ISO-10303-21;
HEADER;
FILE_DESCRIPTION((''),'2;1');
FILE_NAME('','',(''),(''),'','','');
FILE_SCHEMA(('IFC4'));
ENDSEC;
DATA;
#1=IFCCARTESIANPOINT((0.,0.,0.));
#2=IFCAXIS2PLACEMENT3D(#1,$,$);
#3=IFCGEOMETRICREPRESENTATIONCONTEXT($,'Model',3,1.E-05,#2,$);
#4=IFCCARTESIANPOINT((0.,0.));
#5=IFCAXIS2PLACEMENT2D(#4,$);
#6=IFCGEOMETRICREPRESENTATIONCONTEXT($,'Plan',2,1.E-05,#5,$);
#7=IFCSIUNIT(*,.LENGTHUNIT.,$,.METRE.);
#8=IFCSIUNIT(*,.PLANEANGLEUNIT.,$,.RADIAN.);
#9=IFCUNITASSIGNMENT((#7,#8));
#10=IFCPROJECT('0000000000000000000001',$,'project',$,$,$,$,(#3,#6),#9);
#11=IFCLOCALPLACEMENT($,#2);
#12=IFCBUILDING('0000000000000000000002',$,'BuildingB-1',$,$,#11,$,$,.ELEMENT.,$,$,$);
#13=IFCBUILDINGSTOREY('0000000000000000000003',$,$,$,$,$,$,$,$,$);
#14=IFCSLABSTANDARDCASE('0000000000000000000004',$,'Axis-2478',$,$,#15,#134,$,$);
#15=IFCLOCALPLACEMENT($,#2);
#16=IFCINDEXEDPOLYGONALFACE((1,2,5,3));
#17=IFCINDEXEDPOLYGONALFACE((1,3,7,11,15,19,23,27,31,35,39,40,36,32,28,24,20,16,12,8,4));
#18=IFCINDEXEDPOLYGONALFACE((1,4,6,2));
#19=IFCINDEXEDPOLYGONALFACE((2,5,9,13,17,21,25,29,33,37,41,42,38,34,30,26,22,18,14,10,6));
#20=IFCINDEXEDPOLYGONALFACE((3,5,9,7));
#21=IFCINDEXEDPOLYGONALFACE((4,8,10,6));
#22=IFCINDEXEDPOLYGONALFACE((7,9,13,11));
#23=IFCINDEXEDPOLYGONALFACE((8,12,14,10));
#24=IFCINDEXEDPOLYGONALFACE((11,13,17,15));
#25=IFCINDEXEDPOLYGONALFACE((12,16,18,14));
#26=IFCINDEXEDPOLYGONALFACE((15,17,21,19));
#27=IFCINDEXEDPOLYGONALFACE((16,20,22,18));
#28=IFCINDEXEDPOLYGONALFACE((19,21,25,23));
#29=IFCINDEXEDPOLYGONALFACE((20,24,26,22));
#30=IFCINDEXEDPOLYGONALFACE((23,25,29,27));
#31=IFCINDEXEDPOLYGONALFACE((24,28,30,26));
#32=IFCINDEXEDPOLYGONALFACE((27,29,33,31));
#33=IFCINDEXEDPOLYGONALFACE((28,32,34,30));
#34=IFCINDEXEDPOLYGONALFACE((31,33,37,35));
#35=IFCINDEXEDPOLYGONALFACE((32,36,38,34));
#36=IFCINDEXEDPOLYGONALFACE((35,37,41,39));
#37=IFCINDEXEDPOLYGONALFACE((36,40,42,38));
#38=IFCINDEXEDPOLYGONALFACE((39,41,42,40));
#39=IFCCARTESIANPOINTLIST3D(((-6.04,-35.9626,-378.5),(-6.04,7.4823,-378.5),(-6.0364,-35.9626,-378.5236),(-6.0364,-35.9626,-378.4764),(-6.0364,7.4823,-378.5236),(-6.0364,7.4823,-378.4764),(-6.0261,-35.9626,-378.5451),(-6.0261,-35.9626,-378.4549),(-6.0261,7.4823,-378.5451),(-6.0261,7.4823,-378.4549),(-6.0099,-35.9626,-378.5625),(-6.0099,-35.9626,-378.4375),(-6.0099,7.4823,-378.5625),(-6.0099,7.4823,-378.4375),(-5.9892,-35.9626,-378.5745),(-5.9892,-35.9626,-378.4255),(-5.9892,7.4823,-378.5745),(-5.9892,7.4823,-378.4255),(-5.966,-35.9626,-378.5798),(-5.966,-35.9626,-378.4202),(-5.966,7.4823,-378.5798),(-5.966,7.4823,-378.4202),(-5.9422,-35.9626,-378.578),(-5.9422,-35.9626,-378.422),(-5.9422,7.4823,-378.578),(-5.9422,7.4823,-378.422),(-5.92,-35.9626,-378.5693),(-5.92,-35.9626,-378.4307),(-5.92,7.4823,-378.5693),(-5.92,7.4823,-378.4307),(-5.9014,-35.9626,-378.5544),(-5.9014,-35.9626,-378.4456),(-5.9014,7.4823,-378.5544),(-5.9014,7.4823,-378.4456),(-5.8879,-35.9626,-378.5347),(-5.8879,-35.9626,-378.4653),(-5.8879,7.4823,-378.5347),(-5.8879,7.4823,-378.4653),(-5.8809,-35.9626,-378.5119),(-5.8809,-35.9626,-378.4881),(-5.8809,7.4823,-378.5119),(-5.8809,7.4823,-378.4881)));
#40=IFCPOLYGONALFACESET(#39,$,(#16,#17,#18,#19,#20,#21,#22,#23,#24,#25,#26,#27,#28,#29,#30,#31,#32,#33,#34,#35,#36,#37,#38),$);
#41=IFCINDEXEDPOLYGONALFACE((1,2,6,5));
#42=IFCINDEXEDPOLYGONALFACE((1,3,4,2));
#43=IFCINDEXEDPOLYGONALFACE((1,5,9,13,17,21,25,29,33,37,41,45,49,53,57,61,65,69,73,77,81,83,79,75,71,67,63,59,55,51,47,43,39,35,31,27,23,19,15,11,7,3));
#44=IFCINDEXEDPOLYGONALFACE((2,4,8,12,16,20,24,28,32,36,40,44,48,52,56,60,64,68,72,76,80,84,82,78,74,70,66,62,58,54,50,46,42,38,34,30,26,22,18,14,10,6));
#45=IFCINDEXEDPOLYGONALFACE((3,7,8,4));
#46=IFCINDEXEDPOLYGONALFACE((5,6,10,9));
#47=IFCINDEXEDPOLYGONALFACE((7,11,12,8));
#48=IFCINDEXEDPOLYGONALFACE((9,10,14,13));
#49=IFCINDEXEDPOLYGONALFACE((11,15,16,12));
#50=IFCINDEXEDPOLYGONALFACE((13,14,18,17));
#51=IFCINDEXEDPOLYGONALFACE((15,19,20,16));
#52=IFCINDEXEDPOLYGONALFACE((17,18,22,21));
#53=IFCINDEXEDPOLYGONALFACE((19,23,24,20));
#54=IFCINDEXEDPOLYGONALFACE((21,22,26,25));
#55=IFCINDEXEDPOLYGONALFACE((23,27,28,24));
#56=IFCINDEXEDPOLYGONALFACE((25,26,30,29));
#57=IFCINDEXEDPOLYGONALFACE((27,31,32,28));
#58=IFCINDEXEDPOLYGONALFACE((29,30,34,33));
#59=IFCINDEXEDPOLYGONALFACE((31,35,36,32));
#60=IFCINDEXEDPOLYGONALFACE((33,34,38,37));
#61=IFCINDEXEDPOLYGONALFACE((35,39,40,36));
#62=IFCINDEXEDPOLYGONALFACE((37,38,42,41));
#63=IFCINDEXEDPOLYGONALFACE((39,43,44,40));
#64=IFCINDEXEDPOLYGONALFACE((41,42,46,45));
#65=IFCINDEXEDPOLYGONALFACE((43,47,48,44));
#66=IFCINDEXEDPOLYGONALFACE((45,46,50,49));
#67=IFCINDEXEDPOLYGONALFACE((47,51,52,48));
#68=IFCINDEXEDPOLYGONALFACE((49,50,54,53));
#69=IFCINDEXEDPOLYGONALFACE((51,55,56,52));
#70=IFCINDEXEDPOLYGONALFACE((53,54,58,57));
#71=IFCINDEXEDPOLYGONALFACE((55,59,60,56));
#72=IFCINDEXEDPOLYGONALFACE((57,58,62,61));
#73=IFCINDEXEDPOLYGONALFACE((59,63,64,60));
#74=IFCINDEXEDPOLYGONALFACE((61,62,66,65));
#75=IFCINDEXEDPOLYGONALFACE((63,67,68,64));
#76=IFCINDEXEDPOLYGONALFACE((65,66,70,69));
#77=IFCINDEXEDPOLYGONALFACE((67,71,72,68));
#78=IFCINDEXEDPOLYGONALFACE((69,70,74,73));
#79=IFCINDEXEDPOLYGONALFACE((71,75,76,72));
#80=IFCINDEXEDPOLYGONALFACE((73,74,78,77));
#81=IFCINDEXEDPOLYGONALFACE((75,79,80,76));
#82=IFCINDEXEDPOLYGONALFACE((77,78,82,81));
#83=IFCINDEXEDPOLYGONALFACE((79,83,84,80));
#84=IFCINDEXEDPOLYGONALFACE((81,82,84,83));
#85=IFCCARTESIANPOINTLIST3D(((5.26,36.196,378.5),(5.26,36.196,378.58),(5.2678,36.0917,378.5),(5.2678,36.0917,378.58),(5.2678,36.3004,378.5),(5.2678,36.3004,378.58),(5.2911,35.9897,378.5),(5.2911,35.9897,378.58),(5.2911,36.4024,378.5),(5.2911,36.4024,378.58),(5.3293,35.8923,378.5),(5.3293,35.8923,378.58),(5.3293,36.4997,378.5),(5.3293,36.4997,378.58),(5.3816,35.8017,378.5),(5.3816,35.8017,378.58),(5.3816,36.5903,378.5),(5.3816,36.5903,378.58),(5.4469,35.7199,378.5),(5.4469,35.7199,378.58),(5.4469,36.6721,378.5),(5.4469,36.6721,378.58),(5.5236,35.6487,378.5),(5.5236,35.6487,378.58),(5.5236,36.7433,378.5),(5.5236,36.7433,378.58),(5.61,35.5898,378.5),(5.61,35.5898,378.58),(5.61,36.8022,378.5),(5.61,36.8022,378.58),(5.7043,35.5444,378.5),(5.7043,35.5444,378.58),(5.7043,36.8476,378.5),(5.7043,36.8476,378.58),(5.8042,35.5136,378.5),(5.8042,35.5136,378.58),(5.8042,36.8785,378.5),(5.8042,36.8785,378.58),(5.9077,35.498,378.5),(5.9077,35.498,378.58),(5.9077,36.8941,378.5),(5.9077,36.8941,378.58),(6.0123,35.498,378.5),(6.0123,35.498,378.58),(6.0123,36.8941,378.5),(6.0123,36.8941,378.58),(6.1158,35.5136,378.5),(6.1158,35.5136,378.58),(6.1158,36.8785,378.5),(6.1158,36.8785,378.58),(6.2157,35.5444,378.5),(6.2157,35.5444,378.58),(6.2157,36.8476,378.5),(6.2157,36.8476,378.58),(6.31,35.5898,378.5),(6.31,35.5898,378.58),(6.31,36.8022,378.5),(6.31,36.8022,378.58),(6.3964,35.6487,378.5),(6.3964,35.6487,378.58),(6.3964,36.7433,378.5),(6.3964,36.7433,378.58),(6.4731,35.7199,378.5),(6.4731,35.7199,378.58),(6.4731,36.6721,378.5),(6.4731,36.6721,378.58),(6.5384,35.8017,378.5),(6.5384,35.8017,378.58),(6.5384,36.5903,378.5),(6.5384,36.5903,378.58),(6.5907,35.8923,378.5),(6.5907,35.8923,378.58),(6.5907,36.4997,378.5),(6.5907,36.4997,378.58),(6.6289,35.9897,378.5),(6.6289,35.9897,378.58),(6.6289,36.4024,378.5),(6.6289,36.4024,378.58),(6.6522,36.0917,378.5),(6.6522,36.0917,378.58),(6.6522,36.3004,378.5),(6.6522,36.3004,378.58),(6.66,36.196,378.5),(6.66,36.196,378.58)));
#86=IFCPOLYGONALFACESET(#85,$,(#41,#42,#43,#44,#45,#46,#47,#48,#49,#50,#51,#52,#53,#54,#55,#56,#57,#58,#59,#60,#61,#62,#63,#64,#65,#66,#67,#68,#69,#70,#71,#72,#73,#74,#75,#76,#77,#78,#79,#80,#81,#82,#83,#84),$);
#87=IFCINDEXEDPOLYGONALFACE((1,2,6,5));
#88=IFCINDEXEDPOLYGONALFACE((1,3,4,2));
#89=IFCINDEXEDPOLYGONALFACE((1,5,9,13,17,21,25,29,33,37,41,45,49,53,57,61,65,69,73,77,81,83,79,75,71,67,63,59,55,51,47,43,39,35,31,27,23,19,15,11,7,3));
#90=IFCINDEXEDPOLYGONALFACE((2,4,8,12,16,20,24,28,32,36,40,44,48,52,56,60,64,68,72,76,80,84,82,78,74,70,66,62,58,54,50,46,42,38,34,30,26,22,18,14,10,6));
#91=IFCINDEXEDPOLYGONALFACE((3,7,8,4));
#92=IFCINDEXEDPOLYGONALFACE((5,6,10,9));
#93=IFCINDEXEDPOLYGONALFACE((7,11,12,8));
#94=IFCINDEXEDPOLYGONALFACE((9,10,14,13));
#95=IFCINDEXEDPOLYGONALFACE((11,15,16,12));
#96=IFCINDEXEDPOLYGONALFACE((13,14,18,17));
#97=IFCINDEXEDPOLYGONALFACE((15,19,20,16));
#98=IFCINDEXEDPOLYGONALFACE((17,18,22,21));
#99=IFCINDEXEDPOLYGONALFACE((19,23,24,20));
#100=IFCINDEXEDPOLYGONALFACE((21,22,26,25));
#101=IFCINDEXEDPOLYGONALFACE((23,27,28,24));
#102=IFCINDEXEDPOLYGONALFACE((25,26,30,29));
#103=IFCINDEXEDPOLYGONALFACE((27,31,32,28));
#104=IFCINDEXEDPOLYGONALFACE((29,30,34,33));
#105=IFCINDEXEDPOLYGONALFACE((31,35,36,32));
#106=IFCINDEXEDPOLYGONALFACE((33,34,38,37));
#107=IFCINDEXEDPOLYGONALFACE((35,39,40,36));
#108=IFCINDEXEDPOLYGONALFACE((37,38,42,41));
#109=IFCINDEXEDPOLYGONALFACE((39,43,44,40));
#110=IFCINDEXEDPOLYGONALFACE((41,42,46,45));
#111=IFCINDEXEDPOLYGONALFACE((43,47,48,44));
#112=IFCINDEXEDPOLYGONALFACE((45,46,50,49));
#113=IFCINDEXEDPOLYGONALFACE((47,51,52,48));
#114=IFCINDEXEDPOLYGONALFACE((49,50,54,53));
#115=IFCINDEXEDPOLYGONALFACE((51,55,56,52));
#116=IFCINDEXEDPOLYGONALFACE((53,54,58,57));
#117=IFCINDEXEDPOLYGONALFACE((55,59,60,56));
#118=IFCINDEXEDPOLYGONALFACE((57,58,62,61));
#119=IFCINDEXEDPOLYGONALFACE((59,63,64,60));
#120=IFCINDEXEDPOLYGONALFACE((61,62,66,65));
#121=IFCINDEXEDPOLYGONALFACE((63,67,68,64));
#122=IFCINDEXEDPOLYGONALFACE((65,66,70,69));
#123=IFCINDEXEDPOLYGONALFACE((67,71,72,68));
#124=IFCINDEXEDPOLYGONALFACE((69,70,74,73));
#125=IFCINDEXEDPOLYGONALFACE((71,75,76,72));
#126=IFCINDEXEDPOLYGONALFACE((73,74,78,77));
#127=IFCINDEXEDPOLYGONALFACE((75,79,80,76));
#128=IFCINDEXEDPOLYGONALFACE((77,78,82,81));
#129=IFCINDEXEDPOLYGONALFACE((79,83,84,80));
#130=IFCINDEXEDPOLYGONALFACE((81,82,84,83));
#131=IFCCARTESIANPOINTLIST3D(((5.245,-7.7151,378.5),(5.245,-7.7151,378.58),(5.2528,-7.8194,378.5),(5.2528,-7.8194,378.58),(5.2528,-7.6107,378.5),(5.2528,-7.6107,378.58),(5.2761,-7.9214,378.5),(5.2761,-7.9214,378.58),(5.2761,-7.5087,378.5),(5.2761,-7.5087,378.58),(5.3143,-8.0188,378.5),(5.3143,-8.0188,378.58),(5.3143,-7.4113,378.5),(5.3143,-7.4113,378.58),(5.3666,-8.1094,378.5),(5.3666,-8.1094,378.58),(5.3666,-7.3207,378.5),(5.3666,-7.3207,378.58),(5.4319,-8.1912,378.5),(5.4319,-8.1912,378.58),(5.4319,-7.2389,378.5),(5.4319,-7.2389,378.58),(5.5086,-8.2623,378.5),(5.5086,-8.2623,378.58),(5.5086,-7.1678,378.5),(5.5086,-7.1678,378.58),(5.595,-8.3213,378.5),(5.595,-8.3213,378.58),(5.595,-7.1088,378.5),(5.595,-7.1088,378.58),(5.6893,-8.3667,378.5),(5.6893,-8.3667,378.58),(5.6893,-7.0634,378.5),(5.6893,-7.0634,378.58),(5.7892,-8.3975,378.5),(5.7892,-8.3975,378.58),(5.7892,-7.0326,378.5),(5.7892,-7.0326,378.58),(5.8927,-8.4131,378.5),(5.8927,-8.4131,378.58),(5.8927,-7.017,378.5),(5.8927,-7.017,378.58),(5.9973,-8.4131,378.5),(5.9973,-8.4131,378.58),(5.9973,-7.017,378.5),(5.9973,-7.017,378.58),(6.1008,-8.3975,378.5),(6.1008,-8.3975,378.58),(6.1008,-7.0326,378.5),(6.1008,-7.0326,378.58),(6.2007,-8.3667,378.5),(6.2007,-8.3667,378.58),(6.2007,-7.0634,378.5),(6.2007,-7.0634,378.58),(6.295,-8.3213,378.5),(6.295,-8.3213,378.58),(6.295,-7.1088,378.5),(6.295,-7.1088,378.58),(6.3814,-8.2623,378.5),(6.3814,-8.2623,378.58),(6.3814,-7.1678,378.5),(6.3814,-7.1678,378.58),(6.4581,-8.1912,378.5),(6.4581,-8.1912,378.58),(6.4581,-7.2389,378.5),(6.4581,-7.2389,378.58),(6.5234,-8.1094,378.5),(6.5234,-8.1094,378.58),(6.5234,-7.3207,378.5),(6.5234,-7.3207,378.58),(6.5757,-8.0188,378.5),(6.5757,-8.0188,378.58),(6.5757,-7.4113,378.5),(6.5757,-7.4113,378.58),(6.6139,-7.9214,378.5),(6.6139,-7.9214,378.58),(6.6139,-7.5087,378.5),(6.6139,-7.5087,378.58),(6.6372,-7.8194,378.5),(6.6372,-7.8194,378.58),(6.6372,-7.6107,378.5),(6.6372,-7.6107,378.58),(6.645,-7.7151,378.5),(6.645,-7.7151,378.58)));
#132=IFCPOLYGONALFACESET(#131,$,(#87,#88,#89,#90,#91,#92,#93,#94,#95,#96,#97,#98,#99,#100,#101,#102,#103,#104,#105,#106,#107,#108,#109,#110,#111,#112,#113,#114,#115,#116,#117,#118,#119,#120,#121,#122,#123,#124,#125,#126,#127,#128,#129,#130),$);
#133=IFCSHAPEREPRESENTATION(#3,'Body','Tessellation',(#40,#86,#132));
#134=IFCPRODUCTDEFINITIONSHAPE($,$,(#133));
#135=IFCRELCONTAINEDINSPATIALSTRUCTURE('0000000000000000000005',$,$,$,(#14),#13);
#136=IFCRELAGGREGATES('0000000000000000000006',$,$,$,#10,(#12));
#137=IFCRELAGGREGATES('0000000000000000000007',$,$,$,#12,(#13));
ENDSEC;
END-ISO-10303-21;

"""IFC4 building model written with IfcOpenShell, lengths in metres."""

from ifc_helpers import new_model, entity, si_unit, frame, origin, origin_2d, place, context, project, spatial, circle, extrude, element, save


model = new_model("IFC4")

# Units and contexts
model_context = context("Model", 3, precision=1e-05, world=origin())
plan_context = context("Plan", 2, precision=1e-05, world=origin_2d())
ifc_project = project(units=[si_unit("LENGTHUNIT", "METRE"), si_unit("PLANEANGLEUNIT", "RADIAN")], contexts=[model_context, plan_context])

# Building, storey
building_placement = place(None, origin())
building = spatial("IfcBuilding", under=ifc_project, at=building_placement, Name="BuildingB-1", CompositionType="ELEMENT")
storey = spatial("IfcBuildingStorey", under=building)

# Slab
element("IfcSlabStandardCase", 1, inside=storey, Name="Axis-2478", context=model_context, shape_type="AdvancedSweptSolid", body=[
    entity("IfcSurfaceCurveSweptAreaSolid", entity("IfcCircleProfileDef", "AREA", None, None, 0.08), None, entity("IfcPolyline", [entity("IfcCartesianPoint", [5.96, 35.9626, 378.5]), entity("IfcCartesianPoint", [5.96, -7.4823, 378.5])]), None, None, entity("IfcPlane", entity("IfcAxis2Placement3D", entity("IfcCartesianPoint", [5.96, 35.9626, 378.5]), entity("IfcDirection", [0.0, 0.0, 1.0]), entity("IfcDirection", [1.0, 0.0, 0.0])))),
    extrude(circle(Radius=0.7), frame((5.96, 36.196, 378.5)), (0.0, 0.0, 1.0), 0.08),
    extrude(circle(Radius=0.7), frame((5.945, -7.7151, 378.5)), (0.0, 0.0, 1.0), 0.08),
])

save(model, "model.ifc")
